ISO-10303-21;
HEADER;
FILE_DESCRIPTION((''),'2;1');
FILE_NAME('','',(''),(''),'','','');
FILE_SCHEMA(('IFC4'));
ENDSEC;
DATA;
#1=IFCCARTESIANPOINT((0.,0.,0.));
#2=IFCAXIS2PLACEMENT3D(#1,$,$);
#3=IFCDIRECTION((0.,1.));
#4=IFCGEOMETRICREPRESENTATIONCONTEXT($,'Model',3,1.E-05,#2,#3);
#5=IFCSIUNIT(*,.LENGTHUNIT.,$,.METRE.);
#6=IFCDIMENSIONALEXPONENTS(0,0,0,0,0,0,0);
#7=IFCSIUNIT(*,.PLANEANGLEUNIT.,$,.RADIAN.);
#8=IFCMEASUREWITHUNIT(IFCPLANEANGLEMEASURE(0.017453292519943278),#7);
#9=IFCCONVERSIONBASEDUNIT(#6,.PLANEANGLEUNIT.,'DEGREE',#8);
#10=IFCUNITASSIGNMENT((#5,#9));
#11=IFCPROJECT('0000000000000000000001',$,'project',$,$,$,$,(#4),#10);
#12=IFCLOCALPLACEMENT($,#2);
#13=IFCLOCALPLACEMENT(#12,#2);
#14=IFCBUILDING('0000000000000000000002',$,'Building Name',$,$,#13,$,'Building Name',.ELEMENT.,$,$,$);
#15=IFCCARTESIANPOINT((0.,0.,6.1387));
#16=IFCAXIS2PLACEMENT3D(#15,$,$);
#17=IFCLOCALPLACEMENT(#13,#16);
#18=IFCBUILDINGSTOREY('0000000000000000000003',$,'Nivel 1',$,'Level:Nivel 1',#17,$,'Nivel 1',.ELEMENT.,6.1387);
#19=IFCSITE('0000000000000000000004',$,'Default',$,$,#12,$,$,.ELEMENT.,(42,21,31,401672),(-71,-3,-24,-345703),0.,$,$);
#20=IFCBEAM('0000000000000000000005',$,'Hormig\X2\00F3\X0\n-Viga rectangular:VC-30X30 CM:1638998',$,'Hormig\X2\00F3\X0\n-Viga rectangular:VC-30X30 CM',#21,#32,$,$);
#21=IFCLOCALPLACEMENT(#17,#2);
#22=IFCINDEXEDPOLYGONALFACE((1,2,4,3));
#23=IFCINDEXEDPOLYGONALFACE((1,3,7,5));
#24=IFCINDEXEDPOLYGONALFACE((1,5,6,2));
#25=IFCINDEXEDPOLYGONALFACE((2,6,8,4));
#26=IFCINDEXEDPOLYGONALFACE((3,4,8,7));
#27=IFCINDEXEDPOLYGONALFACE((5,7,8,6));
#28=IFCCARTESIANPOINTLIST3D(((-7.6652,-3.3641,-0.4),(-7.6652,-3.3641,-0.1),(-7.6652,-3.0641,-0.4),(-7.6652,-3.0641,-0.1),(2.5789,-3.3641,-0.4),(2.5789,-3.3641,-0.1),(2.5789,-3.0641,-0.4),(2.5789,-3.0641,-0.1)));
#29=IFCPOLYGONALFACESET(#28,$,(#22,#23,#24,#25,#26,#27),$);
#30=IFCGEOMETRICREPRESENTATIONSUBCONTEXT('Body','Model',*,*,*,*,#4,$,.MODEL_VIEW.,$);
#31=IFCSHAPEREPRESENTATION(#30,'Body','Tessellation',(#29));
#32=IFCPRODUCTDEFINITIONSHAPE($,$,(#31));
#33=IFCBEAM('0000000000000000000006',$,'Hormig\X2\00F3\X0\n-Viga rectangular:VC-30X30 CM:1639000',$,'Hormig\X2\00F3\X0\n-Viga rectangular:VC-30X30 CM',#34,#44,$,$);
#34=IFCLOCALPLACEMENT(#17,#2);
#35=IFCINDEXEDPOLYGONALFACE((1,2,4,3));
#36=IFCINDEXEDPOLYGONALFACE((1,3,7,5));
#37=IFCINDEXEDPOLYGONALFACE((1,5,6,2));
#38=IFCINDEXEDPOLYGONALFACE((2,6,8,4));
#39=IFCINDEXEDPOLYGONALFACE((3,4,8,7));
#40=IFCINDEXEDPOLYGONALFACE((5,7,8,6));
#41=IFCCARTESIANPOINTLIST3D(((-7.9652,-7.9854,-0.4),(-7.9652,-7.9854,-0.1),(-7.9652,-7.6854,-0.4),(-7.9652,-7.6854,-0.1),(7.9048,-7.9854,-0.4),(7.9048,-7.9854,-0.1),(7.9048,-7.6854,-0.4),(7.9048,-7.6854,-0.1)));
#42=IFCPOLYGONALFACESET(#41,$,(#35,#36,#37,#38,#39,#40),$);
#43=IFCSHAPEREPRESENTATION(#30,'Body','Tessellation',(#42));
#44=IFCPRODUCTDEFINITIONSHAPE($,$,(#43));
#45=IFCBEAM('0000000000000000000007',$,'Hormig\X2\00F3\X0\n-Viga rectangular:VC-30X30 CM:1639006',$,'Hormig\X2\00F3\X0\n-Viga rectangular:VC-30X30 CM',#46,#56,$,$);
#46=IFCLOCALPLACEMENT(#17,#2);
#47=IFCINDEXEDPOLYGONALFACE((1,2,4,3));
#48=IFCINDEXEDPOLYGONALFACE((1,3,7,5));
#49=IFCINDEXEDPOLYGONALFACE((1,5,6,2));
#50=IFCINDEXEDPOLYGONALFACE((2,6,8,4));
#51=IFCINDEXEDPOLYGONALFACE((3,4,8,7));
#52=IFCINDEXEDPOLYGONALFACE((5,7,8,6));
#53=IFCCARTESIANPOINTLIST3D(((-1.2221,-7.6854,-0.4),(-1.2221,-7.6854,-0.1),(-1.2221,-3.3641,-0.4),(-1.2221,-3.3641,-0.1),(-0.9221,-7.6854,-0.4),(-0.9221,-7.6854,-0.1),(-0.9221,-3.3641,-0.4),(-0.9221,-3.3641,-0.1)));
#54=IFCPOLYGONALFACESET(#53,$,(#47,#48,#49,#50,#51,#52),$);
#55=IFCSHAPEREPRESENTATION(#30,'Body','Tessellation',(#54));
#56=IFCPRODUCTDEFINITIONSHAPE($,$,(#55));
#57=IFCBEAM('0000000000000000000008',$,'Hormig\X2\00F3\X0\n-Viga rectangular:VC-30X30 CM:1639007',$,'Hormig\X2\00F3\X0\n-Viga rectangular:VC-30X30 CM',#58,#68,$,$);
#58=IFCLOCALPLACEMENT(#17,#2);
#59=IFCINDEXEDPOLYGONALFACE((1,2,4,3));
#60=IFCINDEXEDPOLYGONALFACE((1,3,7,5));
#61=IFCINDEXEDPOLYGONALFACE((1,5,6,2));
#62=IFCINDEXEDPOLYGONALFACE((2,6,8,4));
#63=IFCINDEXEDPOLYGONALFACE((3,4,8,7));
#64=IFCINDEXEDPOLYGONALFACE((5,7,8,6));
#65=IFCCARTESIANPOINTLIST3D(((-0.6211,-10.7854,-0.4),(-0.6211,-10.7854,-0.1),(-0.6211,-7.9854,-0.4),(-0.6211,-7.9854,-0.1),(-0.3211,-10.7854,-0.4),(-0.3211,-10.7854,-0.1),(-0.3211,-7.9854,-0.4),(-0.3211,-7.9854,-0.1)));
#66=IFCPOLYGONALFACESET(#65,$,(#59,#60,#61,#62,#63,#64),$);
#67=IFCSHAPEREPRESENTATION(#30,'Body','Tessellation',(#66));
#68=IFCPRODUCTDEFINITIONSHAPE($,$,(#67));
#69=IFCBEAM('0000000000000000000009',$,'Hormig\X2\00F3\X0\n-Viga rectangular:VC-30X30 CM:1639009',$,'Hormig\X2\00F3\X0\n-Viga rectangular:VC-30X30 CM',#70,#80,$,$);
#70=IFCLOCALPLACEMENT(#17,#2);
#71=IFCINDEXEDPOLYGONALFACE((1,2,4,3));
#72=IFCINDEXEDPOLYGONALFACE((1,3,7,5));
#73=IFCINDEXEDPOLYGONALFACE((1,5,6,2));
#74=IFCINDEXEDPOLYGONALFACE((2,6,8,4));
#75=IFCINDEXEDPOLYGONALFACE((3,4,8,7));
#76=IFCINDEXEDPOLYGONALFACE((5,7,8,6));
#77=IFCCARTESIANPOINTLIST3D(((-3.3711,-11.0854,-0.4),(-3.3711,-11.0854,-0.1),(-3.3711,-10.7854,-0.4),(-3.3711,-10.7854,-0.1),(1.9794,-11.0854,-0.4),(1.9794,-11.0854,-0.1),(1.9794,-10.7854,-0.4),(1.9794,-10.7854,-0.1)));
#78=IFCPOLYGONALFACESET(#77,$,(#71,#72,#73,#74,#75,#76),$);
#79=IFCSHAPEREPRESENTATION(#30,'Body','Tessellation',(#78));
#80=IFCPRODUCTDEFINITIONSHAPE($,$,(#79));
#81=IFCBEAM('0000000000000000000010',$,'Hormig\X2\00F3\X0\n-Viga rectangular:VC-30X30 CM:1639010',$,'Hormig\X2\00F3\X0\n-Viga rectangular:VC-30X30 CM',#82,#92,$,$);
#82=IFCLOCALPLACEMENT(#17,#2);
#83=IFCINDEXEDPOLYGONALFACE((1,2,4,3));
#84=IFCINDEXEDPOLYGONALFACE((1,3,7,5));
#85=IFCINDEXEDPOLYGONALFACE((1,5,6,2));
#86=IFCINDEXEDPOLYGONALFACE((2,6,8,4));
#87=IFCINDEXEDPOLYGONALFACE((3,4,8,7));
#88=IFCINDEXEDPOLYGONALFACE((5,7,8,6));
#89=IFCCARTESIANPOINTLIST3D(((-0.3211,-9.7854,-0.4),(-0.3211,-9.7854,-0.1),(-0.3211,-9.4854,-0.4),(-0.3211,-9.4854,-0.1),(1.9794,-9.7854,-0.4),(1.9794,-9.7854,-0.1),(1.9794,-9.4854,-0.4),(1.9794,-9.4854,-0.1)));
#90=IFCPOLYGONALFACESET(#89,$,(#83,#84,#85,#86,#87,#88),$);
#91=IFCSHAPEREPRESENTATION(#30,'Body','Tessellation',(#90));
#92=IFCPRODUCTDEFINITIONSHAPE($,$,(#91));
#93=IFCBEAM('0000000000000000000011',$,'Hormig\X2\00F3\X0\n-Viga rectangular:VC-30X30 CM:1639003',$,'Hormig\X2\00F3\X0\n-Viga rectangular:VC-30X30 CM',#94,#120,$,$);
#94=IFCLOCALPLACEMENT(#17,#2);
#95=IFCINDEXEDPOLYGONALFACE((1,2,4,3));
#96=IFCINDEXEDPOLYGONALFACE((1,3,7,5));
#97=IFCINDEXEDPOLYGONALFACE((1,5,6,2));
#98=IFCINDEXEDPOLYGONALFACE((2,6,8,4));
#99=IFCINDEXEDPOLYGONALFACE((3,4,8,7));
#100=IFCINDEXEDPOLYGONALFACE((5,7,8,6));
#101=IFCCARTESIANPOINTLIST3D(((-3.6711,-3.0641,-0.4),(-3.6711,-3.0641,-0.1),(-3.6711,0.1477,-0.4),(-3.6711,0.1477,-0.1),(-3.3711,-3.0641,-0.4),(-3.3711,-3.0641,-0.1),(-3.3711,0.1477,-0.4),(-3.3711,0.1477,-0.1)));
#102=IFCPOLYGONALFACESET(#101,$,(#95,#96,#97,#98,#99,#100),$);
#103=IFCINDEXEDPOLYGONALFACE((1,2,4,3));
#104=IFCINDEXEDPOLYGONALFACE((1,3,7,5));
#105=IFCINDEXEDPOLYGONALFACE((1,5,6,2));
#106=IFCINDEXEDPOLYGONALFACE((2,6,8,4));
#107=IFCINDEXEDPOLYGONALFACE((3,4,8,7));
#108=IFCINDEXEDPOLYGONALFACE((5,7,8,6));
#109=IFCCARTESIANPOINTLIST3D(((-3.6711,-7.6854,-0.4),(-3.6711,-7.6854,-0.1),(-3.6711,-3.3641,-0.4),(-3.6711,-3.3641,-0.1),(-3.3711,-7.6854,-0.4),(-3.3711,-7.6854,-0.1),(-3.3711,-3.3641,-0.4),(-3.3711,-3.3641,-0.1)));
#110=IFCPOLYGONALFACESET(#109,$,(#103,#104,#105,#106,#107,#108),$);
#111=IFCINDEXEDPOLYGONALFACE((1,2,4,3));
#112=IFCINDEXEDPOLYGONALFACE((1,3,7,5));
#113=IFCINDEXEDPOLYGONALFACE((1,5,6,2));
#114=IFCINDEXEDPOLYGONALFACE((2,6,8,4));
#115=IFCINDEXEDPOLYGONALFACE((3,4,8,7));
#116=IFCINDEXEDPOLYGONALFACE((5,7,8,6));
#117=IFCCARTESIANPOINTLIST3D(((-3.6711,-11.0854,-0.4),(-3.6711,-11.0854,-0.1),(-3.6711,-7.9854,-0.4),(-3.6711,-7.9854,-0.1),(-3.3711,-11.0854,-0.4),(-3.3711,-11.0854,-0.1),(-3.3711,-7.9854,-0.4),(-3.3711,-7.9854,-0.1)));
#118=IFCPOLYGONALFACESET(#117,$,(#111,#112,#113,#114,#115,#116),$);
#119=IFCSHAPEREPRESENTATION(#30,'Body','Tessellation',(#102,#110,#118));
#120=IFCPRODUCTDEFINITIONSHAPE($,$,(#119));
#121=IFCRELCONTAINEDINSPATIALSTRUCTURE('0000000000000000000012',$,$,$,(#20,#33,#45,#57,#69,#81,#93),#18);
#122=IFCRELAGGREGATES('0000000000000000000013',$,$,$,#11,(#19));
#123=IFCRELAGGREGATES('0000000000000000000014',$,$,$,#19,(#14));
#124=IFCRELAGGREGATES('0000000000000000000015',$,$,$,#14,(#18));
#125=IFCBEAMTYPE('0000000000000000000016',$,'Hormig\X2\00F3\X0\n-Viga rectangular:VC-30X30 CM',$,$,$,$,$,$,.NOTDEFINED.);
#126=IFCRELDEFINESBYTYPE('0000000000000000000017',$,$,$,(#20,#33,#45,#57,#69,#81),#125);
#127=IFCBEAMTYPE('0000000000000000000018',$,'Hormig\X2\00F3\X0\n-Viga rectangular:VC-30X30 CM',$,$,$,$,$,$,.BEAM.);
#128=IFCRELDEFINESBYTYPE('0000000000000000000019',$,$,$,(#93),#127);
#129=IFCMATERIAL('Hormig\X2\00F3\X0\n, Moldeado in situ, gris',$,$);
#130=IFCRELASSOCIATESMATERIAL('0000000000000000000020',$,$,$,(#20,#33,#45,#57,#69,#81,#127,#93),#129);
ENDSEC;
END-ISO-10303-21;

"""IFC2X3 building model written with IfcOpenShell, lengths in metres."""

from ifc_helpers import new_model, entity, si_unit, converted_unit, direction, frame, frame_2d, origin, origin_2d_with_axis, place, context, subcontext, project, spatial, rectangle, extrude, source, transform, mapped, material, type_object, type_shapes, element, save


model = new_model("IFC2X3")

# Units and contexts
model_context = context("Model", 3, precision=1e-05, world=origin(), true_north=direction((0.0, 1.0)))
body_context = subcontext(model_context, "Body", "Model", "MODEL_VIEW")
ifc_project = project(units=[si_unit("LENGTHUNIT", "METRE"), converted_unit("PLANEANGLEUNIT", "DEGREE", entity("IfcPlaneAngleMeasure", 0.017453292519943278), si_unit("PLANEANGLEUNIT", "RADIAN"), dimensions=[0, 0, 0, 0, 0, 0, 0])], contexts=[model_context])

# Site, building, storey
site_placement = place(None, origin())
site = spatial("IfcSite", under=ifc_project, at=site_placement, Name="Default", CompositionType="ELEMENT", RefLatitude=(42, 21, 31, 401672), RefLongitude=(-71, -3, -24, -345703), RefElevation=0.0)
building_placement = place(site_placement, origin())
building = spatial("IfcBuilding", under=site, at=building_placement, Name="Building Name", LongName="Building Name", CompositionType="ELEMENT")
storey_placement = place(building_placement, frame((0.0, 0.0, 6.1387)))
storey = spatial("IfcBuildingStorey", under=building, at=storey_placement, Name="Nivel 1", ObjectType="Level:Nivel 1", LongName="Nivel 1", CompositionType="ELEMENT", Elevation=6.1387)

# Shared definitions
ifc_material_1 = material(Name="Hormigón, Moldeado in situ, gris")

# Beams
beam_type_1 = type_object("IfcBeamType", Name="Hormigón-Viga rectangular:VC-30X30 CM", PredefinedType="NOTDEFINED")
beam_1_placement = place(storey_placement, frame((-7.8152, -3.2141, -0.1)))
element("IfcBeam", 1, at=beam_1_placement, inside=storey, type_object=beam_type_1, material=ifc_material_1, Name="Hormigón-Viga rectangular:VC-30X30 CM:1638998", ObjectType="Hormigón-Viga rectangular:VC-30X30 CM", context=body_context, shape_type="SweptSolid", body=[
    extrude(rectangle(XDim=0.3, YDim=0.3, at=origin_2d_with_axis()), frame((0.15, 0.0, -0.15), z_axis=(1.0, 0.0, 0.0), x_axis=(0.0, 0.0, -1.0)), (0.0, 0.0, 1.0), 10.2442),
])
beam_2_placement = place(storey_placement, frame((-7.8152, -7.8354, -0.1)))
element("IfcBeam", 2, at=beam_2_placement, inside=storey, type_object=beam_type_1, material=ifc_material_1, Name="Hormigón-Viga rectangular:VC-30X30 CM:1639000", ObjectType="Hormigón-Viga rectangular:VC-30X30 CM", context=body_context, shape_type="SweptSolid", body=[
    extrude(rectangle(XDim=0.3, YDim=0.3, at=origin_2d_with_axis()), frame((-0.15, 0.0, -0.15), z_axis=(1.0, 0.0, 0.0), x_axis=(0.0, 0.0, -1.0)), (0.0, 0.0, 1.0), 15.87),
])
beam_3_placement = place(storey_placement, frame((-1.0721, -3.2141, -0.1), z_axis=(0.0, 0.0, 1.0), x_axis=(0.0, -1.0, 0.0)))
element("IfcBeam", 3, at=beam_3_placement, inside=storey, type_object=beam_type_1, material=ifc_material_1, Name="Hormigón-Viga rectangular:VC-30X30 CM:1639006", ObjectType="Hormigón-Viga rectangular:VC-30X30 CM", context=body_context, shape_type="SweptSolid", body=[
    extrude(rectangle(XDim=0.3, YDim=0.3, at=frame_2d((0.0, 0.0), x_axis=(1.0, 0.0))), frame((0.15, 0.0, -0.15), z_axis=(1.0, 0.0, 0.0), x_axis=(0.0, 0.0, -1.0)), (0.0, 0.0, 1.0), 4.3214),
])
beam_4_placement = place(storey_placement, frame((-0.4711, -7.8354, -0.1), z_axis=(0.0, 0.0, 1.0), x_axis=(0.0, -1.0, 0.0)))
element("IfcBeam", 4, at=beam_4_placement, inside=storey, type_object=beam_type_1, material=ifc_material_1, Name="Hormigón-Viga rectangular:VC-30X30 CM:1639007", ObjectType="Hormigón-Viga rectangular:VC-30X30 CM", context=body_context, shape_type="SweptSolid", body=[
    extrude(rectangle(XDim=0.3, YDim=0.3, at=frame_2d((0.0, 0.0), x_axis=(1.0, 0.0))), frame((0.15, 0.0, -0.15), z_axis=(1.0, 0.0, 0.0), x_axis=(0.0, 0.0, -1.0)), (0.0, 0.0, 1.0), 2.8),
])
beam_5_placement = place(storey_placement, frame((-3.5211, -10.9354, -0.1)))
element("IfcBeam", 5, at=beam_5_placement, inside=storey, type_object=beam_type_1, material=ifc_material_1, Name="Hormigón-Viga rectangular:VC-30X30 CM:1639009", ObjectType="Hormigón-Viga rectangular:VC-30X30 CM", context=body_context, shape_type="SweptSolid", body=[
    extrude(rectangle(XDim=0.3, YDim=0.3, at=frame_2d((0.0, 0.0), x_axis=(1.0, 0.0))), frame((0.15, 0.0, -0.15), z_axis=(1.0, 0.0, 0.0), x_axis=(0.0, 0.0, -1.0)), (0.0, 0.0, 1.0), 5.3505),
])
beam_6_placement = place(storey_placement, frame((-0.4711, -9.6354, -0.1)))
element("IfcBeam", 6, at=beam_6_placement, inside=storey, type_object=beam_type_1, material=ifc_material_1, Name="Hormigón-Viga rectangular:VC-30X30 CM:1639010", ObjectType="Hormigón-Viga rectangular:VC-30X30 CM", context=body_context, shape_type="SweptSolid", body=[
    extrude(rectangle(XDim=0.3, YDim=0.3, at=frame_2d((0.0, 0.0), x_axis=(1.0, 0.0))), frame((0.15, 0.0, -0.15), z_axis=(1.0, 0.0, 0.0), x_axis=(0.0, 0.0, -1.0)), (0.0, 0.0, 1.0), 2.3005),
])
beam_type_2 = type_object("IfcBeamType", Name="Hormigón-Viga rectangular:VC-30X30 CM", PredefinedType="BEAM", material=ifc_material_1)
shared_shape_1 = source(origin(), body_context, "Body", "SweptSolid", [
    extrude(rectangle(XDim=0.3, YDim=0.3, at=frame_2d((0.0, 0.0), x_axis=(0.0, 1.0))), frame((-3.5211, 0.1477, 5.8887), z_axis=(0.0, -1.0, 0.0), x_axis=(-1.0, 0.0, 0.0)), (0.0, 0.0, 1.0), 3.2118),
    extrude(rectangle(XDim=0.3, YDim=0.3, at=frame_2d((0.0, 0.0), x_axis=(0.0, 1.0))), frame((-3.5211, -3.3641, 5.8887), z_axis=(0.0, -1.0, 0.0), x_axis=(-1.0, 0.0, 0.0)), (0.0, 0.0, 1.0), 4.3214),
    extrude(rectangle(XDim=0.3, YDim=0.3, at=frame_2d((0.0, 0.0), x_axis=(0.0, 1.0))), frame((-3.5211, -7.9854, 5.8887), z_axis=(0.0, -1.0, 0.0), x_axis=(-1.0, 0.0, 0.0)), (0.0, 0.0, 1.0), 3.1),
])
type_shapes(beam_type_2, [shared_shape_1])
beam_7_placement = place(storey_placement, frame((0.0, 0.0, -6.1387)))
element("IfcBeam", 7, at=beam_7_placement, inside=storey, type_object=beam_type_2, material=ifc_material_1, Name="Hormigón-Viga rectangular:VC-30X30 CM:1639003", ObjectType="Hormigón-Viga rectangular:VC-30X30 CM", context=body_context, shape_type="MappedRepresentation", body=[
    mapped(shared_shape_1, transform((0.0, 0.0, 0.0), scale=1.0)),
])

save(model, "model.ifc")
